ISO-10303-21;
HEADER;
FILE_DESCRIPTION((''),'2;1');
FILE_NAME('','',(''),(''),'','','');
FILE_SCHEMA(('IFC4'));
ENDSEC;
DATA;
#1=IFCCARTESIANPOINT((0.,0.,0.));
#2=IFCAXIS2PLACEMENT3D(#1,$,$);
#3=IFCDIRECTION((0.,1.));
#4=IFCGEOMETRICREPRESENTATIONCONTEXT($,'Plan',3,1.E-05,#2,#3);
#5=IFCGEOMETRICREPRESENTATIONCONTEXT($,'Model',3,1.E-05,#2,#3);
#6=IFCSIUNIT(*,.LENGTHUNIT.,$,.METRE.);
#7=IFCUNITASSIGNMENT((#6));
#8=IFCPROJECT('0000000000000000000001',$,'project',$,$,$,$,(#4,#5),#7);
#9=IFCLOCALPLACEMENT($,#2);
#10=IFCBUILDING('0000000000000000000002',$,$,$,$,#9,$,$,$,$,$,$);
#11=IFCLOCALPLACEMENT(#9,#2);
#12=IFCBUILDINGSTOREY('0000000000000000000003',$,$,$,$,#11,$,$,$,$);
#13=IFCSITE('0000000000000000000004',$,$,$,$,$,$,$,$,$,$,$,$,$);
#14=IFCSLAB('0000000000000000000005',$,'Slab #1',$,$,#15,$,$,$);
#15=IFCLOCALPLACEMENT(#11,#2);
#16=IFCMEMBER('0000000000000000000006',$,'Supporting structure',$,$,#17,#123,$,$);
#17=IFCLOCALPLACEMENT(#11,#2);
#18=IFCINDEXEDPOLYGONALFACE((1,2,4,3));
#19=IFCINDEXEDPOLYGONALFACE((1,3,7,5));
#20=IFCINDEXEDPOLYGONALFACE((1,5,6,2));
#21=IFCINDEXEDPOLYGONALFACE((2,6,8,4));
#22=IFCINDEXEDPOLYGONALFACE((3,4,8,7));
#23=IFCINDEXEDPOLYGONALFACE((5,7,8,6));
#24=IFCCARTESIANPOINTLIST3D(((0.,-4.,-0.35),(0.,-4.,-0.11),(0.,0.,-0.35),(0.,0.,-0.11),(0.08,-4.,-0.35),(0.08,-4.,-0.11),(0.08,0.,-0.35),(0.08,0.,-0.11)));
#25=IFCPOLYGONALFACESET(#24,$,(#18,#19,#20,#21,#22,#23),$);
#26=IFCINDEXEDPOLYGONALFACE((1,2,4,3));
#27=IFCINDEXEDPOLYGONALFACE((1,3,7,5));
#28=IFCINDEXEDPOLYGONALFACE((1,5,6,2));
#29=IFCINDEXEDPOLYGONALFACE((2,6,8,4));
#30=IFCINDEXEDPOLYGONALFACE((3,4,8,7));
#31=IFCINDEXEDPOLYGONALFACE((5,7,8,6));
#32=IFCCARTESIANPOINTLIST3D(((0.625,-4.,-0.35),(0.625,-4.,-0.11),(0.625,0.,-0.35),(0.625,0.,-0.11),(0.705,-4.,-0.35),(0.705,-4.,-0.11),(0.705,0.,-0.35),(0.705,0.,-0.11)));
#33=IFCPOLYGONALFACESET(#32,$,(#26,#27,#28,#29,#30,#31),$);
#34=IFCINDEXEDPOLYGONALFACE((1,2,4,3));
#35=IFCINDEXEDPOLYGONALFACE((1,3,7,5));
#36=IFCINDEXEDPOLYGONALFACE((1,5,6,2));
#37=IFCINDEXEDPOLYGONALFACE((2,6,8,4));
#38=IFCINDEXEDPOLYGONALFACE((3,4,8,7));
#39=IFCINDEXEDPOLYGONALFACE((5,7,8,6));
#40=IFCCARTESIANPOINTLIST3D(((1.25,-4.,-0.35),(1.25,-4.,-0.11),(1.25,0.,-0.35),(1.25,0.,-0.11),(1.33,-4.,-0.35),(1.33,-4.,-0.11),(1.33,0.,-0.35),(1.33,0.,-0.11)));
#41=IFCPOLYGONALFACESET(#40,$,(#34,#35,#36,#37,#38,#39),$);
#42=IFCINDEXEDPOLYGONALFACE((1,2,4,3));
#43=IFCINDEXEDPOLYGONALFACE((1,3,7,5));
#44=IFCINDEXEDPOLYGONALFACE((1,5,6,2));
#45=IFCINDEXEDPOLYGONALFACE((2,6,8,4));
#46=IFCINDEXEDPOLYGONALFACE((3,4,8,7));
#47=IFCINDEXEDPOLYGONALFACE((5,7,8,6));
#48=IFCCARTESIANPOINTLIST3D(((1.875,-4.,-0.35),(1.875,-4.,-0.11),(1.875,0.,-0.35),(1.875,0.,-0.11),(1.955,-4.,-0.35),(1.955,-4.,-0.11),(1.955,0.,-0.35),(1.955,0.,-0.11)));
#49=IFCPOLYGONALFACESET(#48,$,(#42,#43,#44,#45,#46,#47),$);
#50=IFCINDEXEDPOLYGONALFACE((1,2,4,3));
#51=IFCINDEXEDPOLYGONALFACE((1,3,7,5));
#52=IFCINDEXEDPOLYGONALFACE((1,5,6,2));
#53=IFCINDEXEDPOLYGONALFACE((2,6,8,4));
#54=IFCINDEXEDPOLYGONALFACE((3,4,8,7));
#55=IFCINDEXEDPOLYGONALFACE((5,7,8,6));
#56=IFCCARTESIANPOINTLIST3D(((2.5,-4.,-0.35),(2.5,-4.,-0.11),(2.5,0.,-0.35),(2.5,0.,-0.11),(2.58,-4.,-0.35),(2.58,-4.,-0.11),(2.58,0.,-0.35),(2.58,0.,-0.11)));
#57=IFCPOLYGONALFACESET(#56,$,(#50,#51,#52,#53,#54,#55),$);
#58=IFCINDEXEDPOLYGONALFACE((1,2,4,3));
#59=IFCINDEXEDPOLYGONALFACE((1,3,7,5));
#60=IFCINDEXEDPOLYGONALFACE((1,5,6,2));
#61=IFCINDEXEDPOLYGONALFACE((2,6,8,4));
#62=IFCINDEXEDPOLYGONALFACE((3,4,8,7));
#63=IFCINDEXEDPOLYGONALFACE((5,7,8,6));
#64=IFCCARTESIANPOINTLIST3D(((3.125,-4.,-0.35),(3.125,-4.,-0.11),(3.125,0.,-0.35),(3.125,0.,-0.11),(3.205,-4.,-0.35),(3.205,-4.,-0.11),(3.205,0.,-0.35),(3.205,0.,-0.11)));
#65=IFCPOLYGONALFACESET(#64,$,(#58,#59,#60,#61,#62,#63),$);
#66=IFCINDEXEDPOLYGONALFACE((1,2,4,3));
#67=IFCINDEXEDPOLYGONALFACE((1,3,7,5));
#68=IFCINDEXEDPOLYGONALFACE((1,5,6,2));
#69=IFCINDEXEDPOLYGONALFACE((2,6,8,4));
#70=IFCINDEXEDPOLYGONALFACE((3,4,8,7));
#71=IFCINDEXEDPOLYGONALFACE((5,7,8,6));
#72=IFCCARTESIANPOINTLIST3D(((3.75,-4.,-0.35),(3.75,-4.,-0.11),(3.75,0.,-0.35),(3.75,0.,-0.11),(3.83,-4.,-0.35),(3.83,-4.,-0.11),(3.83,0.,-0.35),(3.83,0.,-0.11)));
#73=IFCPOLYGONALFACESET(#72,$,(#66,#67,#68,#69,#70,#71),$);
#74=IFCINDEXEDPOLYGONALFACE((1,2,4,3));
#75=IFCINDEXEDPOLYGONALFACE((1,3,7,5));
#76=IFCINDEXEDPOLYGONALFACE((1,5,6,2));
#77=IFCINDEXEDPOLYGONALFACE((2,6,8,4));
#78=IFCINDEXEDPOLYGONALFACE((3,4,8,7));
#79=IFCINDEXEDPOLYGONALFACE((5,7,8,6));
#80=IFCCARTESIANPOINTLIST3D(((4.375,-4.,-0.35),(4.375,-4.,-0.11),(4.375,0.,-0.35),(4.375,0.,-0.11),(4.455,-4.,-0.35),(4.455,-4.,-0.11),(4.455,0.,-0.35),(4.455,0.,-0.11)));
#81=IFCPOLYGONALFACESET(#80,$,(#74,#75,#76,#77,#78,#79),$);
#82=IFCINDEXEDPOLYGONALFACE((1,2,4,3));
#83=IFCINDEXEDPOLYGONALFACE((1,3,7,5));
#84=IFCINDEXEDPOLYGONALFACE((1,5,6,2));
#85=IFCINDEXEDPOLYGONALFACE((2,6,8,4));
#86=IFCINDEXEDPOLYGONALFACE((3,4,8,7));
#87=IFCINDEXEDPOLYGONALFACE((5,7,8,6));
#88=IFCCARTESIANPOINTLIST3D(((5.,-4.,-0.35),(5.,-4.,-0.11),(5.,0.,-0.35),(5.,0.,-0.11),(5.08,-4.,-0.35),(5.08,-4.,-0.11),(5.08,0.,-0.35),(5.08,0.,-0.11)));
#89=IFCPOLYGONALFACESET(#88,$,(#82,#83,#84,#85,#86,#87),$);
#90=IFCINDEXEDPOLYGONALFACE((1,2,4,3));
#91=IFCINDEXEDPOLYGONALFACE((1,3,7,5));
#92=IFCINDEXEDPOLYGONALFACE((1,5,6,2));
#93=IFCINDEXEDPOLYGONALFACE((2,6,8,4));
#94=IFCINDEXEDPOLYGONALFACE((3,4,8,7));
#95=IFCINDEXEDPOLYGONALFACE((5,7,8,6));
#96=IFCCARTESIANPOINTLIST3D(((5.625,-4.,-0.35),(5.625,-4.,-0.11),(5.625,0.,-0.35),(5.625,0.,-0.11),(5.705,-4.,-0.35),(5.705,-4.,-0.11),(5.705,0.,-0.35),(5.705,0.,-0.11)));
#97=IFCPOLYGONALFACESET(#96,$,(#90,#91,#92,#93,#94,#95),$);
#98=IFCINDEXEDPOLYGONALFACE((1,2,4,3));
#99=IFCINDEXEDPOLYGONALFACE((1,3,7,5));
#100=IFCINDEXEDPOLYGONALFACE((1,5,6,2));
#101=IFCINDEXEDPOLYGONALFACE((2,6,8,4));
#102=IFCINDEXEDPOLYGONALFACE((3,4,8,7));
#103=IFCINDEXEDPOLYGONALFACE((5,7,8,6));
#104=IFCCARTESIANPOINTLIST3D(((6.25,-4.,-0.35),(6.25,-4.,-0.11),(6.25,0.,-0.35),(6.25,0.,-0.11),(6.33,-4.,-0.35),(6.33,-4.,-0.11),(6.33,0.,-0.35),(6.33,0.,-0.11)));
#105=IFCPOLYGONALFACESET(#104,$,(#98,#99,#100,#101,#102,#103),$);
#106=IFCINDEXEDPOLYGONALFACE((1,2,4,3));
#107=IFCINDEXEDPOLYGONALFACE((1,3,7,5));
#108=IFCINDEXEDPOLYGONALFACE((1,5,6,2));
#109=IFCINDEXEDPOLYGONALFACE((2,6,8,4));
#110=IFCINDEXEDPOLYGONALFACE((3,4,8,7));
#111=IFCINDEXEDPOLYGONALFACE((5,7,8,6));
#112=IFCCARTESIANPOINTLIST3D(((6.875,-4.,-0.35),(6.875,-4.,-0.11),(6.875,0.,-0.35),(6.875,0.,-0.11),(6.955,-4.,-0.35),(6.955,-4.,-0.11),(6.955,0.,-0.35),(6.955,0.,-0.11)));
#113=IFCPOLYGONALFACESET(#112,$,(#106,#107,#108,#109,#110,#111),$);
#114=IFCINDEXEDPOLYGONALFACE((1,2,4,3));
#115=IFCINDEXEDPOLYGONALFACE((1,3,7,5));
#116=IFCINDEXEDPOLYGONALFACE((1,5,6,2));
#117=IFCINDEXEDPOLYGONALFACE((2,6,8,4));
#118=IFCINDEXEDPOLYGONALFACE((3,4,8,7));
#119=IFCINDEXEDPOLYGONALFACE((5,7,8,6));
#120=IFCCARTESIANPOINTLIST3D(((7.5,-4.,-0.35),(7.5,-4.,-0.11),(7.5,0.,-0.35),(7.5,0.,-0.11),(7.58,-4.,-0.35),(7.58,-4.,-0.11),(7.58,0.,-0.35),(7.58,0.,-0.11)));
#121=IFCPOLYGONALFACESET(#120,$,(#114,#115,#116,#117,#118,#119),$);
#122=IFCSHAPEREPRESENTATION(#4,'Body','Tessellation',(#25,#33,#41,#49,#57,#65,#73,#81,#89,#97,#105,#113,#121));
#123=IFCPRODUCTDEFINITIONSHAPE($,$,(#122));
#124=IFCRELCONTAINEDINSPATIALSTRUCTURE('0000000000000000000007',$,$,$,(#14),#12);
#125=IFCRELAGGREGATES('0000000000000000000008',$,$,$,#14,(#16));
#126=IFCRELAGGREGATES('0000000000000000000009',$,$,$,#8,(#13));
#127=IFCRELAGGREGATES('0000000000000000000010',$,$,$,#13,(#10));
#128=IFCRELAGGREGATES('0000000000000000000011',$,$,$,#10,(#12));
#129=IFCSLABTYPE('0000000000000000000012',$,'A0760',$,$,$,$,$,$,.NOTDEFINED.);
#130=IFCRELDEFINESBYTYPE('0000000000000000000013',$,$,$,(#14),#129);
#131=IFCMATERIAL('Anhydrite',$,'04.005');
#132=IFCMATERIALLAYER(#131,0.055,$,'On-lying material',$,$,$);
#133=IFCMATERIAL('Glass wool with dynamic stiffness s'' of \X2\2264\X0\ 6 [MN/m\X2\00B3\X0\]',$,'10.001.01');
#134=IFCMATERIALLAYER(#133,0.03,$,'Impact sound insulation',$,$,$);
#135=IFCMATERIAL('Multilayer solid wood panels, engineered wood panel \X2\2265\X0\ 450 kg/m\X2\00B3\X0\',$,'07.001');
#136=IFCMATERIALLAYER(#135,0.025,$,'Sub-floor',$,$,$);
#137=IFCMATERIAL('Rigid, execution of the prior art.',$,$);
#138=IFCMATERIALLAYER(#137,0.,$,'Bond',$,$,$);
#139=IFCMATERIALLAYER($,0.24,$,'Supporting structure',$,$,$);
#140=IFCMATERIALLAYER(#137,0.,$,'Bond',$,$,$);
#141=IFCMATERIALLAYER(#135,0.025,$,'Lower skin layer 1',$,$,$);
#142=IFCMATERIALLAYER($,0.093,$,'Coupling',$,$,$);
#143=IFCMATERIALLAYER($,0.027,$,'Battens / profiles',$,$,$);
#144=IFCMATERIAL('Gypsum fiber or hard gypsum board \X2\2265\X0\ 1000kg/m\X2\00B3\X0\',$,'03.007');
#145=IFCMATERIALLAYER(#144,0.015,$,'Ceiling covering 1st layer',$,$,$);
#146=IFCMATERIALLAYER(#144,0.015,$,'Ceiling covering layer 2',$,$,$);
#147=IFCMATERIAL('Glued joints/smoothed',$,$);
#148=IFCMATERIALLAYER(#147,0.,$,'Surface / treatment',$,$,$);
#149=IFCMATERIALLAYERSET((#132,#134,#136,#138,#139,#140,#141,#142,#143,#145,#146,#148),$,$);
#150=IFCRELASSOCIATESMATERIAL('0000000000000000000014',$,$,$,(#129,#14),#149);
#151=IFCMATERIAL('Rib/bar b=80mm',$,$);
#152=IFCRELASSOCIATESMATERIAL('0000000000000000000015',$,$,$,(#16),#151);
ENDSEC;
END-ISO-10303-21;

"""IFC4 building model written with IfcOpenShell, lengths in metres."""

from ifc_helpers import new_model, si_unit, direction, frame, frame_2d, origin, place, context, project, spatial, rectangle, extrude, material, layer, layer_set, type_object, element, aggregate, save


model = new_model("IFC4")

# Units and contexts
plan_context = context("Plan", 3, precision=1e-05, world=origin(), true_north=direction((0.0, 1.0)))
model_context = context("Model", 3, precision=1e-05, world=origin(), true_north=direction((0.0, 1.0)))
ifc_project = project(units=[si_unit("LENGTHUNIT", "METRE")], contexts=[plan_context, model_context])

# Site, building, storey
site = spatial("IfcSite", under=ifc_project)
building_placement = place(None, origin())
building = spatial("IfcBuilding", under=site, at=building_placement)
storey_placement = place(building_placement, origin())
storey = spatial("IfcBuildingStorey", under=building, at=storey_placement)

# Slab, member
ifc_material_1 = material(Name="Anhydrite", Category="04.005")
ifc_layer_1 = layer(ifc_material_1, 0.055, Name="On-lying material")
ifc_material_2 = material(Name="Glass wool with dynamic stiffness s' of ≤ 6 [MN/m³]", Category="10.001.01")
ifc_layer_2 = layer(ifc_material_2, 0.03, Name="Impact sound insulation")
ifc_material_3 = material(Name="Multilayer solid wood panels, engineered wood panel ≥ 450 kg/m³", Category="07.001")
ifc_layer_3 = layer(ifc_material_3, 0.025, Name="Sub-floor")
ifc_material_4 = material(Name="Rigid, execution of the prior art.")
ifc_layer_4 = layer(ifc_material_4, 0.0, Name="Bond")
ifc_layer_5 = layer(None, 0.24, Name="Supporting structure")
ifc_layer_6 = layer(ifc_material_4, 0.0, Name="Bond")
ifc_layer_7 = layer(ifc_material_3, 0.025, Name="Lower skin layer 1")
ifc_layer_8 = layer(None, 0.093, Name="Coupling")
ifc_layer_9 = layer(None, 0.027, Name="Battens / profiles")
ifc_material_5 = material(Name="Gypsum fiber or hard gypsum board ≥ 1000kg/m³", Category="03.007")
ifc_layer_10 = layer(ifc_material_5, 0.015, Name="Ceiling covering 1st layer")
ifc_layer_11 = layer(ifc_material_5, 0.015, Name="Ceiling covering layer 2")
ifc_material_6 = material(Name="Glued joints/smoothed")
ifc_layer_12 = layer(ifc_material_6, 0.0, Name="Surface / treatment")
ifc_layer_set = layer_set([ifc_layer_1, ifc_layer_2, ifc_layer_3, ifc_layer_4, ifc_layer_5, ifc_layer_6, ifc_layer_7, ifc_layer_8, ifc_layer_9, ifc_layer_10, ifc_layer_11, ifc_layer_12])
slab_type = type_object("IfcSlabType", Name="A0760", PredefinedType="NOTDEFINED", material=ifc_layer_set)
slab_placement = place(None, frame((0.0, 0.0, 0.0), z_axis=(0.0, 0.0, -1.0), x_axis=(1.0, 0.0, 0.0)))
slab = element("IfcSlab", 1, at=slab_placement, inside=storey, type_object=slab_type, material=ifc_layer_set, Name="Slab #1")
ifc_material_7 = material(Name="Rib/bar b=80mm")
member_1_placement = place(slab_placement, origin())
member_1 = element("IfcMember", 2, at=member_1_placement, material=ifc_material_7, Name="Supporting structure", context=plan_context, shape_type="SweptSolid", body=[
    extrude(rectangle(XDim=0.08, YDim=0.24, at=frame_2d((0.04, 0.12), x_axis=(1.0, 0.0))), frame((0.0, 4.0, 0.11), z_axis=(0.0, -1.0, 0.0), x_axis=(1.0, 0.0, 0.0)), (0.0, 0.0, 1.0), 4.0),
    extrude(rectangle(XDim=0.08, YDim=0.24, at=frame_2d((0.04, 0.12), x_axis=(1.0, 0.0))), frame((0.625, 4.0, 0.11), z_axis=(0.0, -1.0, 0.0), x_axis=(1.0, 0.0, 0.0)), (0.0, 0.0, 1.0), 4.0),
    extrude(rectangle(XDim=0.08, YDim=0.24, at=frame_2d((0.04, 0.12), x_axis=(1.0, 0.0))), frame((1.25, 4.0, 0.11), z_axis=(0.0, -1.0, 0.0), x_axis=(1.0, 0.0, 0.0)), (0.0, 0.0, 1.0), 4.0),
    extrude(rectangle(XDim=0.08, YDim=0.24, at=frame_2d((0.04, 0.12), x_axis=(1.0, 0.0))), frame((1.875, 4.0, 0.11), z_axis=(0.0, -1.0, 0.0), x_axis=(1.0, 0.0, 0.0)), (0.0, 0.0, 1.0), 4.0),
    extrude(rectangle(XDim=0.08, YDim=0.24, at=frame_2d((0.04, 0.12), x_axis=(1.0, 0.0))), frame((2.5, 4.0, 0.11), z_axis=(0.0, -1.0, 0.0), x_axis=(1.0, 0.0, 0.0)), (0.0, 0.0, 1.0), 4.0),
    extrude(rectangle(XDim=0.08, YDim=0.24, at=frame_2d((0.04, 0.12), x_axis=(1.0, 0.0))), frame((3.125, 4.0, 0.11), z_axis=(0.0, -1.0, 0.0), x_axis=(1.0, 0.0, 0.0)), (0.0, 0.0, 1.0), 4.0),
    extrude(rectangle(XDim=0.08, YDim=0.24, at=frame_2d((0.04, 0.12), x_axis=(1.0, 0.0))), frame((3.75, 4.0, 0.11), z_axis=(0.0, -1.0, 0.0), x_axis=(1.0, 0.0, 0.0)), (0.0, 0.0, 1.0), 4.0),
    extrude(rectangle(XDim=0.08, YDim=0.24, at=frame_2d((0.04, 0.12), x_axis=(1.0, 0.0))), frame((4.375, 4.0, 0.11), z_axis=(0.0, -1.0, 0.0), x_axis=(1.0, 0.0, 0.0)), (0.0, 0.0, 1.0), 4.0),
    extrude(rectangle(XDim=0.08, YDim=0.24, at=frame_2d((0.04, 0.12), x_axis=(1.0, 0.0))), frame((5.0, 4.0, 0.11), z_axis=(0.0, -1.0, 0.0), x_axis=(1.0, 0.0, 0.0)), (0.0, 0.0, 1.0), 4.0),
    extrude(rectangle(XDim=0.08, YDim=0.24, at=frame_2d((0.04, 0.12), x_axis=(1.0, 0.0))), frame((5.625, 4.0, 0.11), z_axis=(0.0, -1.0, 0.0), x_axis=(1.0, 0.0, 0.0)), (0.0, 0.0, 1.0), 4.0),
    extrude(rectangle(XDim=0.08, YDim=0.24, at=frame_2d((0.04, 0.12), x_axis=(1.0, 0.0))), frame((6.25, 4.0, 0.11), z_axis=(0.0, -1.0, 0.0), x_axis=(1.0, 0.0, 0.0)), (0.0, 0.0, 1.0), 4.0),
    extrude(rectangle(XDim=0.08, YDim=0.24, at=frame_2d((0.04, 0.12), x_axis=(1.0, 0.0))), frame((6.875, 4.0, 0.11), z_axis=(0.0, -1.0, 0.0), x_axis=(1.0, 0.0, 0.0)), (0.0, 0.0, 1.0), 4.0),
    extrude(rectangle(XDim=0.08, YDim=0.24, at=frame_2d((0.04, 0.12), x_axis=(1.0, 0.0))), frame((7.5, 4.0, 0.11), z_axis=(0.0, -1.0, 0.0), x_axis=(1.0, 0.0, 0.0)), (0.0, 0.0, 1.0), 4.0),
])
aggregate(slab, [member_1])

save(model, "model.ifc")
